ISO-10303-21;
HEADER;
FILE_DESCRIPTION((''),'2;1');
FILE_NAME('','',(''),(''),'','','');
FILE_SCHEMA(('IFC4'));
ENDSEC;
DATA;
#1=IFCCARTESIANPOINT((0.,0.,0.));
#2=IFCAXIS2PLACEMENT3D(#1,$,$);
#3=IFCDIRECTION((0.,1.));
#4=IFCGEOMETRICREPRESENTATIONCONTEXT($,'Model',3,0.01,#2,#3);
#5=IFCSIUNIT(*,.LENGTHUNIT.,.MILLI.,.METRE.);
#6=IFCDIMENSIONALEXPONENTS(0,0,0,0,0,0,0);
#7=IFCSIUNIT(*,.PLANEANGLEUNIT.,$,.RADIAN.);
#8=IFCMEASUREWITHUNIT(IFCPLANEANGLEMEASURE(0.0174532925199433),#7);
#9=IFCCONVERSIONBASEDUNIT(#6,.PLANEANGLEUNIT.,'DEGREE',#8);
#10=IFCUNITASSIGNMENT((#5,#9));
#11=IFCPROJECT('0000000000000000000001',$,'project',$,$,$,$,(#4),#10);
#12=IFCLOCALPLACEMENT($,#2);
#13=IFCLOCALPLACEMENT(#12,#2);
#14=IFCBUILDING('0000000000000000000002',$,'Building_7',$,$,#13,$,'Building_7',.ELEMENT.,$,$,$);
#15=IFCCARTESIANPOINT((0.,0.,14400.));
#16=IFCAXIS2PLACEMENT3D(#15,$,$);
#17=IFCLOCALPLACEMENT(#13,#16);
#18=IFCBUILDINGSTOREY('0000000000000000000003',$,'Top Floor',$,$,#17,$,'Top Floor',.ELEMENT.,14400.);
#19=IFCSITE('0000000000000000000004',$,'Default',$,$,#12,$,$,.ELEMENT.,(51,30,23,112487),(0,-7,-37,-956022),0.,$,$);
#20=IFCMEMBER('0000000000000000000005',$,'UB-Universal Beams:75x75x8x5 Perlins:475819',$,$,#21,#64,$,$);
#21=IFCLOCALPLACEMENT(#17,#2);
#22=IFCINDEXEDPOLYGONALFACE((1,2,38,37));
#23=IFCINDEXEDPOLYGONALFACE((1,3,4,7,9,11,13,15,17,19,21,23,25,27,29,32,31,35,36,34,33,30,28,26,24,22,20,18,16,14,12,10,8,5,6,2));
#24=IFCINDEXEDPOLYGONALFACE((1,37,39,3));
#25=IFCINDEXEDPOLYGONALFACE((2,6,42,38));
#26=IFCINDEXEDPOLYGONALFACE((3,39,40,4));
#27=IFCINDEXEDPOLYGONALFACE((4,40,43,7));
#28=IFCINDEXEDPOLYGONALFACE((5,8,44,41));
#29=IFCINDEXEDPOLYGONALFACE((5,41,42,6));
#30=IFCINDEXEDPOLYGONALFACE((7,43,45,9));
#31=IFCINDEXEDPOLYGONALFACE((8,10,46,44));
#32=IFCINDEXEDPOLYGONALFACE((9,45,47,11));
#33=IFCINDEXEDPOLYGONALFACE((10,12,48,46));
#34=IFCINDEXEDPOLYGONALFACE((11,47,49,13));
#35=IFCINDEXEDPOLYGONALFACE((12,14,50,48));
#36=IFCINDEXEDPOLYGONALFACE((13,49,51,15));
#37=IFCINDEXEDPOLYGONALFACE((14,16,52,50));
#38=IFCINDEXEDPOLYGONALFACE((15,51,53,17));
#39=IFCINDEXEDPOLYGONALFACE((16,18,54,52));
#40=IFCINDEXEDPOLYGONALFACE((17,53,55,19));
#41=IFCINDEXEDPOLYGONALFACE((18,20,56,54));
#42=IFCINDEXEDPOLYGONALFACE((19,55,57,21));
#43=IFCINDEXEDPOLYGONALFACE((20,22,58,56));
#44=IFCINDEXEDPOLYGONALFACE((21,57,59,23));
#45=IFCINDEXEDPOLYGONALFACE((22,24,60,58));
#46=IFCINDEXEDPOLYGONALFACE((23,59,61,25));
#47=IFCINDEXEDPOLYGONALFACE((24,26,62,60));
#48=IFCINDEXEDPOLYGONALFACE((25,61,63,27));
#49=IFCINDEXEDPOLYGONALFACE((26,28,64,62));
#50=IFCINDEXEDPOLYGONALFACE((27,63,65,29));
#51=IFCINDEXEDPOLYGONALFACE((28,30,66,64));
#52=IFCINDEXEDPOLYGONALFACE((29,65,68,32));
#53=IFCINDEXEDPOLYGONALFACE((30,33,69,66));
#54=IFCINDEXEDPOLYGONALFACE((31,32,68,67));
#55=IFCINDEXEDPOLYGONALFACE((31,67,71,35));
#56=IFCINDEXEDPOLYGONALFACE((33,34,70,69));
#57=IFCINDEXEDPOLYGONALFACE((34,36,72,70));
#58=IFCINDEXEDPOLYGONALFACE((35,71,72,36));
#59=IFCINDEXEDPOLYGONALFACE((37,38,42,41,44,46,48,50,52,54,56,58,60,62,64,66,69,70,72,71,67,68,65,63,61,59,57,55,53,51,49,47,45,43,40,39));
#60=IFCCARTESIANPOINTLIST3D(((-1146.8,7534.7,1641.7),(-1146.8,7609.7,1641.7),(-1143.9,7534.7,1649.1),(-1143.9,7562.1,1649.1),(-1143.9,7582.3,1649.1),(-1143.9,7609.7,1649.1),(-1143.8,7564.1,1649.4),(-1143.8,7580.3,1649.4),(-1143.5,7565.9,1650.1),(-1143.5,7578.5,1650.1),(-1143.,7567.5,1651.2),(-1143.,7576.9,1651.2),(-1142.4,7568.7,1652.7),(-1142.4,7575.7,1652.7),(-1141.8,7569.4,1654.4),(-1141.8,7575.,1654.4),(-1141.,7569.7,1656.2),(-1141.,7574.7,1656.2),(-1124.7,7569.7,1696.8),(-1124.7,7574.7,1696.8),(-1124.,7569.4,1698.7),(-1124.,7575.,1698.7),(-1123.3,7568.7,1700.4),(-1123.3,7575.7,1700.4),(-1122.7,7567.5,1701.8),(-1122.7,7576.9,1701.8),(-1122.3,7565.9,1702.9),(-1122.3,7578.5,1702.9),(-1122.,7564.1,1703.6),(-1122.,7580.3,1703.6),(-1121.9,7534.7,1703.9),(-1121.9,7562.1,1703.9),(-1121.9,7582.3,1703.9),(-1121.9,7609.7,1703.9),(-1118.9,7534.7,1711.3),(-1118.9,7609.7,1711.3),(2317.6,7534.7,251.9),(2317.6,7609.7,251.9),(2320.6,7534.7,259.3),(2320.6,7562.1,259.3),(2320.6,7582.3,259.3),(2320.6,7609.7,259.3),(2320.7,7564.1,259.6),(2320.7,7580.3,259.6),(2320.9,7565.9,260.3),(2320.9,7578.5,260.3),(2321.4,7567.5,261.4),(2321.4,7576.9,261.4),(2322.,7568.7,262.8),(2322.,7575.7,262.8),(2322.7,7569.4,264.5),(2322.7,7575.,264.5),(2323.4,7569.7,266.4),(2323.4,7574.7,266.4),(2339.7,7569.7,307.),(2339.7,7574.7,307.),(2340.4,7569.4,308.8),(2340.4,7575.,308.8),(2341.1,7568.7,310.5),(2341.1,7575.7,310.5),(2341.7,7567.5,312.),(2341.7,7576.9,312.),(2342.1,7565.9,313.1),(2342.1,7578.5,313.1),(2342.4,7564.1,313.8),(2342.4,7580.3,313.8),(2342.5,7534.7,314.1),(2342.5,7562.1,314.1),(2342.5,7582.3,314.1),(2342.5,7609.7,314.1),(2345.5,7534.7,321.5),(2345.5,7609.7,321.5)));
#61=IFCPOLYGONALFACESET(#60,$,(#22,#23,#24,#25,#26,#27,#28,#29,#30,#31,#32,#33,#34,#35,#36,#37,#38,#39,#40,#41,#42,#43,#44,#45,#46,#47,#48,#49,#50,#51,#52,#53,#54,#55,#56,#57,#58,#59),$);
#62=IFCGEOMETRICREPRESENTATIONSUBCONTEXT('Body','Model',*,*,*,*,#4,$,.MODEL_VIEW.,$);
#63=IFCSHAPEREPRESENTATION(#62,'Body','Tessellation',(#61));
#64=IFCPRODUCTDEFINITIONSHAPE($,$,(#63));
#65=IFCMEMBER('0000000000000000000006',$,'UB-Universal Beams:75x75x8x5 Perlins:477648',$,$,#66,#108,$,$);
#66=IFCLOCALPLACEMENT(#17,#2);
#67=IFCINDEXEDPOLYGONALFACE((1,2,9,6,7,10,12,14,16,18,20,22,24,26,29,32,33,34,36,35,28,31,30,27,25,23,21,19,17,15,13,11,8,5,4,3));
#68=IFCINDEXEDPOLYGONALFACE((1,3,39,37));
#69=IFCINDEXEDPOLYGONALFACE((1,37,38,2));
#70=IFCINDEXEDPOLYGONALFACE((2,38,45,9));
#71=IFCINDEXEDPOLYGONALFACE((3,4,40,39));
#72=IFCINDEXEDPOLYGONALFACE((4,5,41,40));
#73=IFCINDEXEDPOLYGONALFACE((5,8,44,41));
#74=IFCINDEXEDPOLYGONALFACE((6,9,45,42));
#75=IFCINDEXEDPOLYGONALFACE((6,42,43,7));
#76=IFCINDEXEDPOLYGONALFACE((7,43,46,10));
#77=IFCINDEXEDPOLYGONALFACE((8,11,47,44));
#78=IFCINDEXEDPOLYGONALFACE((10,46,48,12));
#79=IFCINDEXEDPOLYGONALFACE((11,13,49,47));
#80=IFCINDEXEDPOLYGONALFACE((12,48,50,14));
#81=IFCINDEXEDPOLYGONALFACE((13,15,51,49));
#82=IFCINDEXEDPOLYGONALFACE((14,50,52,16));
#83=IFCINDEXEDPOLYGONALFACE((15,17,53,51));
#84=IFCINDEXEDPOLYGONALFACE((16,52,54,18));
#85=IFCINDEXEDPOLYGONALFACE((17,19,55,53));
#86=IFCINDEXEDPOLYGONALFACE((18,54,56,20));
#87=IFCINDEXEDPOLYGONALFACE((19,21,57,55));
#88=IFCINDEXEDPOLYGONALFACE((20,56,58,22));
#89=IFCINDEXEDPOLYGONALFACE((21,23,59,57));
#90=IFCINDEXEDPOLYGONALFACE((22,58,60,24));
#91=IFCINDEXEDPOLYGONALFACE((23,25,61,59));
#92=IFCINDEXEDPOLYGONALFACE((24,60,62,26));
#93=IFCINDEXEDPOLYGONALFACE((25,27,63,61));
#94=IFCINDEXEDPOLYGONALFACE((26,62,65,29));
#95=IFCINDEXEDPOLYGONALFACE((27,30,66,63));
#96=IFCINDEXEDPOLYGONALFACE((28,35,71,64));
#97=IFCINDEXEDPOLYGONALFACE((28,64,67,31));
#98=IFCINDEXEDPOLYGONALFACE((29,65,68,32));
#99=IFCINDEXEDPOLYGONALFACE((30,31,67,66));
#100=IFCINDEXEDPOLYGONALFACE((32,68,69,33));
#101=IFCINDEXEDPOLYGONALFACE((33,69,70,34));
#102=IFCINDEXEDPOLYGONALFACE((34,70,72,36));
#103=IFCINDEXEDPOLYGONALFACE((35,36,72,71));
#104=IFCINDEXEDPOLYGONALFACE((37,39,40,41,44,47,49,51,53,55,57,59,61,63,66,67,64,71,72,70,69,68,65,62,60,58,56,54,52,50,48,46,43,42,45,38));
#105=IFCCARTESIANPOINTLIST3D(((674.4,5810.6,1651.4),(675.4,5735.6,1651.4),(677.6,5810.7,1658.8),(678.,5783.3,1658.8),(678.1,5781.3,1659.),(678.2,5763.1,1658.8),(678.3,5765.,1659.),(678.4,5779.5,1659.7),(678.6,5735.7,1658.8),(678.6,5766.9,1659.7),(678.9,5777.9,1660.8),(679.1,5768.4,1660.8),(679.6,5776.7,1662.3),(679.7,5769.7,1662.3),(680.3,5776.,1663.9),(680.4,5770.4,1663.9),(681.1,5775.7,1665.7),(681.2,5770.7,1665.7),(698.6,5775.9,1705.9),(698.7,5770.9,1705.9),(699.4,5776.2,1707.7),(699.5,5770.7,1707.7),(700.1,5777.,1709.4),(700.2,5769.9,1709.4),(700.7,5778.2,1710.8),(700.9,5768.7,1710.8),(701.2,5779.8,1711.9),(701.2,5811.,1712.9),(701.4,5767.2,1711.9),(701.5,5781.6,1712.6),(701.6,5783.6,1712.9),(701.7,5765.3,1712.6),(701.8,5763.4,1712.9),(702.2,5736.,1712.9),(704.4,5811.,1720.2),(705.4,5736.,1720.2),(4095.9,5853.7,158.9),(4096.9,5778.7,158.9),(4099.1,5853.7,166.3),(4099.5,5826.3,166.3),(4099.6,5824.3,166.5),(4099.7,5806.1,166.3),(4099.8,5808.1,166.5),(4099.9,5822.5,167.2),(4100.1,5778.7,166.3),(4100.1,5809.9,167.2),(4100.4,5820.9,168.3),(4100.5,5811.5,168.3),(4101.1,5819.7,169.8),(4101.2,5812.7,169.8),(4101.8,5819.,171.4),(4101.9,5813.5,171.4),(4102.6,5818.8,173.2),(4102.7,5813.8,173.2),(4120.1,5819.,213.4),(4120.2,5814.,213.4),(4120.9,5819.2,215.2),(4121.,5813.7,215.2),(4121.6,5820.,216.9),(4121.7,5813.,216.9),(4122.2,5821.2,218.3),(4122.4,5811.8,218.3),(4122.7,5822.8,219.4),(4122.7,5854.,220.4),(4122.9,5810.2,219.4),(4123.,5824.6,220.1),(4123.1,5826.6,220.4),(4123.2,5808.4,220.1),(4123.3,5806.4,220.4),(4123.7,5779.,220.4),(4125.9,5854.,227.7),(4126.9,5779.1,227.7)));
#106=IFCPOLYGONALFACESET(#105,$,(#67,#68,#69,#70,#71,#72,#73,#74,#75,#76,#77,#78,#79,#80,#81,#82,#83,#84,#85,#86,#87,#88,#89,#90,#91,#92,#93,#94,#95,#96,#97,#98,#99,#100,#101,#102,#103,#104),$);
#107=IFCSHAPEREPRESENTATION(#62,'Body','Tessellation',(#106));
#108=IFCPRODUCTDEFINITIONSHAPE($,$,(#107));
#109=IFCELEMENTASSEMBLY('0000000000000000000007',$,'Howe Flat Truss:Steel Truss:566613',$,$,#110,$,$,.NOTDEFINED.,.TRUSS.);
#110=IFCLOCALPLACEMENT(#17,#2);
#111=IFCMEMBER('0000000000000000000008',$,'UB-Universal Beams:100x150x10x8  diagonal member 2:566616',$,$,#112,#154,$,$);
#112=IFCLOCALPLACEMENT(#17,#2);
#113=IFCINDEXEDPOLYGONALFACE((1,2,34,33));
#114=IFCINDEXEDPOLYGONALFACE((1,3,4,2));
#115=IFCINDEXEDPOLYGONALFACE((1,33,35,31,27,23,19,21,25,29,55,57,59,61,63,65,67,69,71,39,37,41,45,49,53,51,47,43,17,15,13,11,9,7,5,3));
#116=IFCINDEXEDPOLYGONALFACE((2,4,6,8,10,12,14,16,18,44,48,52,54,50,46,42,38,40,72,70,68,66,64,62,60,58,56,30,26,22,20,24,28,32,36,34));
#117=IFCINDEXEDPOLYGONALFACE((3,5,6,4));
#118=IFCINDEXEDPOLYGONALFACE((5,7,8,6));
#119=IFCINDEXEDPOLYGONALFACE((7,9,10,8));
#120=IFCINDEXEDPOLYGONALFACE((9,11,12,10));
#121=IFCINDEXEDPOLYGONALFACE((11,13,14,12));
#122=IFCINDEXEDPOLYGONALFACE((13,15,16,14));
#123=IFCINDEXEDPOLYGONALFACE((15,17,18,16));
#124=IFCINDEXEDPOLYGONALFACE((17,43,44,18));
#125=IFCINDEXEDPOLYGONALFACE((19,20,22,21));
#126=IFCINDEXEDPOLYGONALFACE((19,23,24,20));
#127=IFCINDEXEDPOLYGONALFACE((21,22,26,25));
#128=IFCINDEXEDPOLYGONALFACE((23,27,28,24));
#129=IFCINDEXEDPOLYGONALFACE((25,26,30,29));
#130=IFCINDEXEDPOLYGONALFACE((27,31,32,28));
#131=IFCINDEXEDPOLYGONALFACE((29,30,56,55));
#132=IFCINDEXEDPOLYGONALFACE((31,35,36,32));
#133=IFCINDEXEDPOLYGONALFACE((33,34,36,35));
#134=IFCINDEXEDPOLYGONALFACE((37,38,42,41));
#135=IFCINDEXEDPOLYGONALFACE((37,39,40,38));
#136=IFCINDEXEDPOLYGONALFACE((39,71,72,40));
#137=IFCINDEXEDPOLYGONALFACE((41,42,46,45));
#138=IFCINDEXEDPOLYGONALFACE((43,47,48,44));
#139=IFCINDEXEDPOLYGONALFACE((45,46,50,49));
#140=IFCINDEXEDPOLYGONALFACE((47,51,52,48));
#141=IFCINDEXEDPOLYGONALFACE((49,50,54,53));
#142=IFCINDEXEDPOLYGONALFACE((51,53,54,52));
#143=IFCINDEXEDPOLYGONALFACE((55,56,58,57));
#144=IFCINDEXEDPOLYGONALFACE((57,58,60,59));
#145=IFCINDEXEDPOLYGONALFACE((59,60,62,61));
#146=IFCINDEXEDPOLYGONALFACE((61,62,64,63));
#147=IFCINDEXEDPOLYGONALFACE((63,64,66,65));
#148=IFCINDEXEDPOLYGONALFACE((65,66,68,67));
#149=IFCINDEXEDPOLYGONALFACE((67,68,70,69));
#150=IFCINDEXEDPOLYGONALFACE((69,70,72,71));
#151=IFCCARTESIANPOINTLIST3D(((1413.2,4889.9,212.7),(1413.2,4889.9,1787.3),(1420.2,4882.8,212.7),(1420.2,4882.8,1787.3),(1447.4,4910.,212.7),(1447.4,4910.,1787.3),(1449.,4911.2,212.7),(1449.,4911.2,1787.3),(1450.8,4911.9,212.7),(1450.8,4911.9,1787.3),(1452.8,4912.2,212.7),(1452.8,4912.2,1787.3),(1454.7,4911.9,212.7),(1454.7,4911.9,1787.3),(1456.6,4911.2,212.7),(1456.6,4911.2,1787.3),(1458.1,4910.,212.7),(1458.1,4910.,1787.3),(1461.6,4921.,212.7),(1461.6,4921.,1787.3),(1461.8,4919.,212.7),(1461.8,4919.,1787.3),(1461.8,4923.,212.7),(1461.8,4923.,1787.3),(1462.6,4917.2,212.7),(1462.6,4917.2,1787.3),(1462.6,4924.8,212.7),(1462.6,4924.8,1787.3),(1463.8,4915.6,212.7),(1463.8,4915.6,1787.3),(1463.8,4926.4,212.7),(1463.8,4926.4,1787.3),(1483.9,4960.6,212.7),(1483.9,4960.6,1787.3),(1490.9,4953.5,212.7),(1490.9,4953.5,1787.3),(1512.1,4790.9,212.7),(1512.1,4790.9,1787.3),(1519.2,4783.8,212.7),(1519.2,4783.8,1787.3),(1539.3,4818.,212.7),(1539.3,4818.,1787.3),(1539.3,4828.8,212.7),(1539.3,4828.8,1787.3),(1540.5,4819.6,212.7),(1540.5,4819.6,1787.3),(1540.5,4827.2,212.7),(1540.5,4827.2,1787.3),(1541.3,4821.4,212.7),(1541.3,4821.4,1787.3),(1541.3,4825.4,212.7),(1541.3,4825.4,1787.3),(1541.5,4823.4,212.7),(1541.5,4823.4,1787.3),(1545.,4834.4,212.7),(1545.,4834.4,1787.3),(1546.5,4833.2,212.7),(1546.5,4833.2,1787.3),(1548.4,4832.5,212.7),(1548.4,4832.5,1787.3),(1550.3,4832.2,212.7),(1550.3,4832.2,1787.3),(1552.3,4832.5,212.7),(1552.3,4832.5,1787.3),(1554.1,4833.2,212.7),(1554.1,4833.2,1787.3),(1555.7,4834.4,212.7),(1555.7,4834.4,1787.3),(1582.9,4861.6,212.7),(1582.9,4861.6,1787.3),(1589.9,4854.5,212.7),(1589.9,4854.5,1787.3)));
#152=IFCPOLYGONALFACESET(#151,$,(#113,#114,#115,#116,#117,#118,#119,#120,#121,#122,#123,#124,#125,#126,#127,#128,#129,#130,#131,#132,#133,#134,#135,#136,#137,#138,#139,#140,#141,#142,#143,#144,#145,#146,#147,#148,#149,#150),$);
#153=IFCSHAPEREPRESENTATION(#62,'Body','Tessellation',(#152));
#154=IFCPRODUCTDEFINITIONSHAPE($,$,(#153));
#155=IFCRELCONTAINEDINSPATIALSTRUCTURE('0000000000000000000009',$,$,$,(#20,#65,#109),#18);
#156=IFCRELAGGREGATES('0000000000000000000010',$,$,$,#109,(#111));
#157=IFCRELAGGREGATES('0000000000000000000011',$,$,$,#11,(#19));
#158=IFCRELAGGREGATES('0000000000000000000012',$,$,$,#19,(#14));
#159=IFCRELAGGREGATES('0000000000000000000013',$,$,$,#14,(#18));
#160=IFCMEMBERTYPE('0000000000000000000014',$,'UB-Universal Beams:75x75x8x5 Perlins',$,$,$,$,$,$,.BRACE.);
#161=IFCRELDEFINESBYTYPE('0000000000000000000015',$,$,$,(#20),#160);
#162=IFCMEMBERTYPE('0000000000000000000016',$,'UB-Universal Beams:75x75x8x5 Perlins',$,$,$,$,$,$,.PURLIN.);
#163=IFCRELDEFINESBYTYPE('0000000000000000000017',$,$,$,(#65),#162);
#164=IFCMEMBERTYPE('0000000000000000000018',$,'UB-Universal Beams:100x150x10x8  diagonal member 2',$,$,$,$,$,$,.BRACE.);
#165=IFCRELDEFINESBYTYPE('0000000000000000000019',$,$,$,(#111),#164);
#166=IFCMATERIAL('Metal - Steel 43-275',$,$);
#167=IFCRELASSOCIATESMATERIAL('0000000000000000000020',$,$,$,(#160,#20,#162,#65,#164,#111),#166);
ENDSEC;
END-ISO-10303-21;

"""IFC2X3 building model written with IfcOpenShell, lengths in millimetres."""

from ifc_helpers import new_model, entity, si_unit, converted_unit, direction, frame, frame_2d, origin, place, context, subcontext, project, spatial, polyline, circle_curve, parameter, trimmed, segment, composite_curve, outline, extrude, source, transform, mapped, material, type_object, type_shapes, element, aggregate, save


model = new_model("IFC2X3")

# Units and contexts
model_context = context("Model", 3, precision=0.01, world=origin(), true_north=direction((0.0, 1.0)))
body_context = subcontext(model_context, "Body", "Model", "MODEL_VIEW")
ifc_project = project(units=[si_unit("LENGTHUNIT", "METRE", prefix="MILLI"), converted_unit("PLANEANGLEUNIT", "DEGREE", entity("IfcPlaneAngleMeasure", 0.0174532925199433), si_unit("PLANEANGLEUNIT", "RADIAN"), dimensions=[0, 0, 0, 0, 0, 0, 0])], contexts=[model_context])

# Site, building, storey
site_placement = place(None, origin())
site = spatial("IfcSite", under=ifc_project, at=site_placement, Name="Default", CompositionType="ELEMENT", RefLatitude=(51, 30, 23, 112487), RefLongitude=(0, -7, -37, -956022), RefElevation=0.0)
building_placement = place(site_placement, origin())
building = spatial("IfcBuilding", under=site, at=building_placement, Name="Building_7", LongName="Building_7", CompositionType="ELEMENT")
storey_placement = place(building_placement, frame((0.0, 0.0, 14400.0)))
storey = spatial("IfcBuildingStorey", under=building, at=storey_placement, Name="Top Floor", LongName="Top Floor", CompositionType="ELEMENT", Elevation=14400.0)

# Members
ifc_material = material(Name="Metal - Steel 43-275")
member_type_1 = type_object("IfcMemberType", Name="UB-Universal Beams:75x75x8x5 Perlins", PredefinedType="BRACE", material=ifc_material)
shared_shape_1 = source(origin(), body_context, "Body", "SweptSolid", [
    extrude(outline(composite_curve([segment(polyline([(-37.5, -29.5), (-37.5, -37.5)]), True, "CONTINUOUS"), segment(polyline([(-37.5, -37.5), (37.5, -37.5)]), True, "CONTINUOUS"), segment(polyline([(37.5, -37.5), (37.5, -29.5)]), True, "CONTINUOUS"), segment(polyline([(37.5, -29.5), (10.1, -29.5)]), True, "CONTINUOUS"), segment(trimmed(circle_curve(frame_2d((10.1, -21.9), x_axis=(1.0, 0.0)), 7.6), [parameter(180.0)], [parameter(270.0)], True, "PARAMETER"), False, "CONTINUOUS"), segment(polyline([(2.5, -21.9), (2.5, 21.9)]), True, "CONTINUOUS"), segment(trimmed(circle_curve(frame_2d((10.1, 21.9), x_axis=(1.0, 0.0)), 7.6), [parameter(90.0)], [parameter(180.0)], True, "PARAMETER"), False, "CONTINUOUS"), segment(polyline([(10.1, 29.5), (37.5, 29.5)]), True, "CONTINUOUS"), segment(polyline([(37.5, 29.5), (37.5, 37.5)]), True, "CONTINUOUS"), segment(polyline([(37.5, 37.5), (-37.5, 37.5)]), True, "CONTINUOUS"), segment(polyline([(-37.5, 37.5), (-37.5, 29.5)]), True, "CONTINUOUS"), segment(polyline([(-37.5, 29.5), (-10.1, 29.5)]), True, "CONTINUOUS"), segment(trimmed(circle_curve(frame_2d((-10.1, 21.9), x_axis=(1.0, 0.0)), 7.6), [parameter(360.0)], [parameter(90.0)], True, "PARAMETER"), False, "CONTINUOUS"), segment(polyline([(-2.5, 21.9), (-2.5, -21.9)]), True, "CONTINUOUS"), segment(trimmed(circle_curve(frame_2d((-10.1, -21.9), x_axis=(1.0, 0.0)), 7.6), [parameter(270.0)], [parameter(360.0)], True, "PARAMETER"), False, "CONTINUOUS"), segment(polyline([(-10.1, -29.5), (-37.5, -29.5)]), True, "CONTINUOUS")], self_intersect=False)), frame((-1859.2, 0.0, 0.0), z_axis=(-1.0, 0.0, 0.0), x_axis=(0.0, -1.0, 0.0)), (0.0, 0.0, -1.0), 3732.8),
])
type_shapes(member_type_1, [shared_shape_1])
member_1_placement = place(storey_placement, frame((606.0, 7572.2, 978.9), z_axis=(0.372323, 0.0, 0.928103), x_axis=(-0.928103, 0.0, 0.372323)))
element("IfcMember", 1, at=member_1_placement, inside=storey, type_object=member_type_1, material=ifc_material, Name="UB-Universal Beams:75x75x8x5 Perlins:475819", context=body_context, shape_type="MappedRepresentation", body=[
    mapped(shared_shape_1, transform((0.0, 0.0, 0.0), scale=1.0)),
])
member_type_2 = type_object("IfcMemberType", Name="UB-Universal Beams:75x75x8x5 Perlins", PredefinedType="PURLIN", material=ifc_material)
shared_shape_2 = source(origin(), body_context, "Body", "SweptSolid", [
    extrude(outline(composite_curve([segment(polyline([(-37.5, -29.5), (-37.5, -37.5)]), True, "CONTINUOUS"), segment(polyline([(-37.5, -37.5), (37.5, -37.5)]), True, "CONTINUOUS"), segment(polyline([(37.5, -37.5), (37.5, -29.5)]), True, "CONTINUOUS"), segment(polyline([(37.5, -29.5), (10.1, -29.5)]), True, "CONTINUOUS"), segment(trimmed(circle_curve(frame_2d((10.1, -21.9), x_axis=(1.0, 0.0)), 7.6), [parameter(180.0)], [parameter(270.0)], True, "PARAMETER"), False, "CONTINUOUS"), segment(polyline([(2.5, -21.9), (2.5, 21.9)]), True, "CONTINUOUS"), segment(trimmed(circle_curve(frame_2d((10.1, 21.9), x_axis=(1.0, 0.0)), 7.6), [parameter(90.0)], [parameter(180.0)], True, "PARAMETER"), False, "CONTINUOUS"), segment(polyline([(10.1, 29.5), (37.5, 29.5)]), True, "CONTINUOUS"), segment(polyline([(37.5, 29.5), (37.5, 37.5)]), True, "CONTINUOUS"), segment(polyline([(37.5, 37.5), (-37.5, 37.5)]), True, "CONTINUOUS"), segment(polyline([(-37.5, 37.5), (-37.5, 29.5)]), True, "CONTINUOUS"), segment(polyline([(-37.5, 29.5), (-10.1, 29.5)]), True, "CONTINUOUS"), segment(trimmed(circle_curve(frame_2d((-10.1, 21.9), x_axis=(1.0, 0.0)), 7.6), [parameter(360.0)], [parameter(90.0)], True, "PARAMETER"), False, "CONTINUOUS"), segment(polyline([(-2.5, 21.9), (-2.5, -21.9)]), True, "CONTINUOUS"), segment(trimmed(circle_curve(frame_2d((-10.1, -21.9), x_axis=(1.0, 0.0)), 7.6), [parameter(270.0)], [parameter(360.0)], True, "PARAMETER"), False, "CONTINUOUS"), segment(polyline([(-10.1, -29.5), (-37.5, -29.5)]), True, "CONTINUOUS")], self_intersect=False)), frame((-1914.8, 0.0, 0.0), z_axis=(-1.0, 0.0, 0.0), x_axis=(0.0, -1.0, 0.0)), (0.0, 0.0, -1.0), 3733.1),
])
type_shapes(member_type_2, [shared_shape_2])
member_2_placement = place(storey_placement, frame((2356.5, 5794.3, 958.8), z_axis=(0.39977, 0.00503, 0.916602), x_axis=(-0.916529, -0.011531, 0.399801)))
element("IfcMember", 2, at=member_2_placement, inside=storey, type_object=member_type_2, material=ifc_material, Name="UB-Universal Beams:75x75x8x5 Perlins:477648", context=body_context, shape_type="MappedRepresentation", body=[
    mapped(shared_shape_2, transform((0.0, 0.0, 0.0), scale=1.0)),
])

# Element assembly, member
assembly_1_placement = place(storey_placement, origin())
assembly_1 = element("IfcElementAssembly", 3, at=assembly_1_placement, inside=storey, Name="Howe Flat Truss:Steel Truss:566613", AssemblyPlace="NOTDEFINED", PredefinedType="TRUSS")
member_type_3 = type_object("IfcMemberType", Name="UB-Universal Beams:100x150x10x8  diagonal member 2", PredefinedType="BRACE", material=ifc_material)
shared_shape_3 = source(origin(), body_context, "Body", "SweptSolid", [
    extrude(outline(composite_curve([segment(polyline([(-50.0, -65.0), (-50.0, -75.0)]), True, "CONTINUOUS"), segment(polyline([(-50.0, -75.0), (50.0, -75.0)]), True, "CONTINUOUS"), segment(polyline([(50.0, -75.0), (50.0, -65.0)]), True, "CONTINUOUS"), segment(polyline([(50.0, -65.0), (11.6, -65.0)]), True, "CONTINUOUS"), segment(trimmed(circle_curve(frame_2d((11.6, -57.4), x_axis=(1.0, 0.0)), 7.6), [parameter(180.0)], [parameter(270.0)], True, "PARAMETER"), False, "CONTINUOUS"), segment(polyline([(4.0, -57.4), (4.0, 57.4)]), True, "CONTINUOUS"), segment(trimmed(circle_curve(frame_2d((11.6, 57.4), x_axis=(1.0, 0.0)), 7.6), [parameter(90.0)], [parameter(180.0)], True, "PARAMETER"), False, "CONTINUOUS"), segment(polyline([(11.6, 65.0), (50.0, 65.0)]), True, "CONTINUOUS"), segment(polyline([(50.0, 65.0), (50.0, 75.0)]), True, "CONTINUOUS"), segment(polyline([(50.0, 75.0), (-50.0, 75.0)]), True, "CONTINUOUS"), segment(polyline([(-50.0, 75.0), (-50.0, 65.0)]), True, "CONTINUOUS"), segment(polyline([(-50.0, 65.0), (-11.6, 65.0)]), True, "CONTINUOUS"), segment(trimmed(circle_curve(frame_2d((-11.6, 57.4), x_axis=(1.0, 0.0)), 7.6), [parameter(360.0)], [parameter(90.0)], True, "PARAMETER"), False, "CONTINUOUS"), segment(polyline([(-4.0, 57.4), (-4.0, -57.4)]), True, "CONTINUOUS"), segment(trimmed(circle_curve(frame_2d((-11.6, -57.4), x_axis=(1.0, 0.0)), 7.6), [parameter(270.0)], [parameter(360.0)], True, "PARAMETER"), False, "CONTINUOUS"), segment(polyline([(-11.6, -65.0), (-50.0, -65.0)]), True, "CONTINUOUS")], self_intersect=False)), frame((-787.3, 0.0, 0.0), z_axis=(-1.0, 0.0, 0.0), x_axis=(0.0, -1.0, 0.0)), (0.0, 0.0, -1.0), 1574.6),
])
type_shapes(member_type_3, [shared_shape_3])
member_3_placement = place(assembly_1_placement, frame((1501.5, 4872.2, 1000.0), z_axis=(0.707107, -0.707107, 0.0), x_axis=(0.0, 0.0, 1.0)))
member_3 = element("IfcMember", 4, at=member_3_placement, type_object=member_type_3, material=ifc_material, Name="UB-Universal Beams:100x150x10x8  diagonal member 2:566616", context=body_context, shape_type="MappedRepresentation", body=[
    mapped(shared_shape_3, transform((0.0, 0.0, 0.0), scale=1.0)),
])

aggregate(assembly_1, [member_3])

save(model, "model.ifc")
